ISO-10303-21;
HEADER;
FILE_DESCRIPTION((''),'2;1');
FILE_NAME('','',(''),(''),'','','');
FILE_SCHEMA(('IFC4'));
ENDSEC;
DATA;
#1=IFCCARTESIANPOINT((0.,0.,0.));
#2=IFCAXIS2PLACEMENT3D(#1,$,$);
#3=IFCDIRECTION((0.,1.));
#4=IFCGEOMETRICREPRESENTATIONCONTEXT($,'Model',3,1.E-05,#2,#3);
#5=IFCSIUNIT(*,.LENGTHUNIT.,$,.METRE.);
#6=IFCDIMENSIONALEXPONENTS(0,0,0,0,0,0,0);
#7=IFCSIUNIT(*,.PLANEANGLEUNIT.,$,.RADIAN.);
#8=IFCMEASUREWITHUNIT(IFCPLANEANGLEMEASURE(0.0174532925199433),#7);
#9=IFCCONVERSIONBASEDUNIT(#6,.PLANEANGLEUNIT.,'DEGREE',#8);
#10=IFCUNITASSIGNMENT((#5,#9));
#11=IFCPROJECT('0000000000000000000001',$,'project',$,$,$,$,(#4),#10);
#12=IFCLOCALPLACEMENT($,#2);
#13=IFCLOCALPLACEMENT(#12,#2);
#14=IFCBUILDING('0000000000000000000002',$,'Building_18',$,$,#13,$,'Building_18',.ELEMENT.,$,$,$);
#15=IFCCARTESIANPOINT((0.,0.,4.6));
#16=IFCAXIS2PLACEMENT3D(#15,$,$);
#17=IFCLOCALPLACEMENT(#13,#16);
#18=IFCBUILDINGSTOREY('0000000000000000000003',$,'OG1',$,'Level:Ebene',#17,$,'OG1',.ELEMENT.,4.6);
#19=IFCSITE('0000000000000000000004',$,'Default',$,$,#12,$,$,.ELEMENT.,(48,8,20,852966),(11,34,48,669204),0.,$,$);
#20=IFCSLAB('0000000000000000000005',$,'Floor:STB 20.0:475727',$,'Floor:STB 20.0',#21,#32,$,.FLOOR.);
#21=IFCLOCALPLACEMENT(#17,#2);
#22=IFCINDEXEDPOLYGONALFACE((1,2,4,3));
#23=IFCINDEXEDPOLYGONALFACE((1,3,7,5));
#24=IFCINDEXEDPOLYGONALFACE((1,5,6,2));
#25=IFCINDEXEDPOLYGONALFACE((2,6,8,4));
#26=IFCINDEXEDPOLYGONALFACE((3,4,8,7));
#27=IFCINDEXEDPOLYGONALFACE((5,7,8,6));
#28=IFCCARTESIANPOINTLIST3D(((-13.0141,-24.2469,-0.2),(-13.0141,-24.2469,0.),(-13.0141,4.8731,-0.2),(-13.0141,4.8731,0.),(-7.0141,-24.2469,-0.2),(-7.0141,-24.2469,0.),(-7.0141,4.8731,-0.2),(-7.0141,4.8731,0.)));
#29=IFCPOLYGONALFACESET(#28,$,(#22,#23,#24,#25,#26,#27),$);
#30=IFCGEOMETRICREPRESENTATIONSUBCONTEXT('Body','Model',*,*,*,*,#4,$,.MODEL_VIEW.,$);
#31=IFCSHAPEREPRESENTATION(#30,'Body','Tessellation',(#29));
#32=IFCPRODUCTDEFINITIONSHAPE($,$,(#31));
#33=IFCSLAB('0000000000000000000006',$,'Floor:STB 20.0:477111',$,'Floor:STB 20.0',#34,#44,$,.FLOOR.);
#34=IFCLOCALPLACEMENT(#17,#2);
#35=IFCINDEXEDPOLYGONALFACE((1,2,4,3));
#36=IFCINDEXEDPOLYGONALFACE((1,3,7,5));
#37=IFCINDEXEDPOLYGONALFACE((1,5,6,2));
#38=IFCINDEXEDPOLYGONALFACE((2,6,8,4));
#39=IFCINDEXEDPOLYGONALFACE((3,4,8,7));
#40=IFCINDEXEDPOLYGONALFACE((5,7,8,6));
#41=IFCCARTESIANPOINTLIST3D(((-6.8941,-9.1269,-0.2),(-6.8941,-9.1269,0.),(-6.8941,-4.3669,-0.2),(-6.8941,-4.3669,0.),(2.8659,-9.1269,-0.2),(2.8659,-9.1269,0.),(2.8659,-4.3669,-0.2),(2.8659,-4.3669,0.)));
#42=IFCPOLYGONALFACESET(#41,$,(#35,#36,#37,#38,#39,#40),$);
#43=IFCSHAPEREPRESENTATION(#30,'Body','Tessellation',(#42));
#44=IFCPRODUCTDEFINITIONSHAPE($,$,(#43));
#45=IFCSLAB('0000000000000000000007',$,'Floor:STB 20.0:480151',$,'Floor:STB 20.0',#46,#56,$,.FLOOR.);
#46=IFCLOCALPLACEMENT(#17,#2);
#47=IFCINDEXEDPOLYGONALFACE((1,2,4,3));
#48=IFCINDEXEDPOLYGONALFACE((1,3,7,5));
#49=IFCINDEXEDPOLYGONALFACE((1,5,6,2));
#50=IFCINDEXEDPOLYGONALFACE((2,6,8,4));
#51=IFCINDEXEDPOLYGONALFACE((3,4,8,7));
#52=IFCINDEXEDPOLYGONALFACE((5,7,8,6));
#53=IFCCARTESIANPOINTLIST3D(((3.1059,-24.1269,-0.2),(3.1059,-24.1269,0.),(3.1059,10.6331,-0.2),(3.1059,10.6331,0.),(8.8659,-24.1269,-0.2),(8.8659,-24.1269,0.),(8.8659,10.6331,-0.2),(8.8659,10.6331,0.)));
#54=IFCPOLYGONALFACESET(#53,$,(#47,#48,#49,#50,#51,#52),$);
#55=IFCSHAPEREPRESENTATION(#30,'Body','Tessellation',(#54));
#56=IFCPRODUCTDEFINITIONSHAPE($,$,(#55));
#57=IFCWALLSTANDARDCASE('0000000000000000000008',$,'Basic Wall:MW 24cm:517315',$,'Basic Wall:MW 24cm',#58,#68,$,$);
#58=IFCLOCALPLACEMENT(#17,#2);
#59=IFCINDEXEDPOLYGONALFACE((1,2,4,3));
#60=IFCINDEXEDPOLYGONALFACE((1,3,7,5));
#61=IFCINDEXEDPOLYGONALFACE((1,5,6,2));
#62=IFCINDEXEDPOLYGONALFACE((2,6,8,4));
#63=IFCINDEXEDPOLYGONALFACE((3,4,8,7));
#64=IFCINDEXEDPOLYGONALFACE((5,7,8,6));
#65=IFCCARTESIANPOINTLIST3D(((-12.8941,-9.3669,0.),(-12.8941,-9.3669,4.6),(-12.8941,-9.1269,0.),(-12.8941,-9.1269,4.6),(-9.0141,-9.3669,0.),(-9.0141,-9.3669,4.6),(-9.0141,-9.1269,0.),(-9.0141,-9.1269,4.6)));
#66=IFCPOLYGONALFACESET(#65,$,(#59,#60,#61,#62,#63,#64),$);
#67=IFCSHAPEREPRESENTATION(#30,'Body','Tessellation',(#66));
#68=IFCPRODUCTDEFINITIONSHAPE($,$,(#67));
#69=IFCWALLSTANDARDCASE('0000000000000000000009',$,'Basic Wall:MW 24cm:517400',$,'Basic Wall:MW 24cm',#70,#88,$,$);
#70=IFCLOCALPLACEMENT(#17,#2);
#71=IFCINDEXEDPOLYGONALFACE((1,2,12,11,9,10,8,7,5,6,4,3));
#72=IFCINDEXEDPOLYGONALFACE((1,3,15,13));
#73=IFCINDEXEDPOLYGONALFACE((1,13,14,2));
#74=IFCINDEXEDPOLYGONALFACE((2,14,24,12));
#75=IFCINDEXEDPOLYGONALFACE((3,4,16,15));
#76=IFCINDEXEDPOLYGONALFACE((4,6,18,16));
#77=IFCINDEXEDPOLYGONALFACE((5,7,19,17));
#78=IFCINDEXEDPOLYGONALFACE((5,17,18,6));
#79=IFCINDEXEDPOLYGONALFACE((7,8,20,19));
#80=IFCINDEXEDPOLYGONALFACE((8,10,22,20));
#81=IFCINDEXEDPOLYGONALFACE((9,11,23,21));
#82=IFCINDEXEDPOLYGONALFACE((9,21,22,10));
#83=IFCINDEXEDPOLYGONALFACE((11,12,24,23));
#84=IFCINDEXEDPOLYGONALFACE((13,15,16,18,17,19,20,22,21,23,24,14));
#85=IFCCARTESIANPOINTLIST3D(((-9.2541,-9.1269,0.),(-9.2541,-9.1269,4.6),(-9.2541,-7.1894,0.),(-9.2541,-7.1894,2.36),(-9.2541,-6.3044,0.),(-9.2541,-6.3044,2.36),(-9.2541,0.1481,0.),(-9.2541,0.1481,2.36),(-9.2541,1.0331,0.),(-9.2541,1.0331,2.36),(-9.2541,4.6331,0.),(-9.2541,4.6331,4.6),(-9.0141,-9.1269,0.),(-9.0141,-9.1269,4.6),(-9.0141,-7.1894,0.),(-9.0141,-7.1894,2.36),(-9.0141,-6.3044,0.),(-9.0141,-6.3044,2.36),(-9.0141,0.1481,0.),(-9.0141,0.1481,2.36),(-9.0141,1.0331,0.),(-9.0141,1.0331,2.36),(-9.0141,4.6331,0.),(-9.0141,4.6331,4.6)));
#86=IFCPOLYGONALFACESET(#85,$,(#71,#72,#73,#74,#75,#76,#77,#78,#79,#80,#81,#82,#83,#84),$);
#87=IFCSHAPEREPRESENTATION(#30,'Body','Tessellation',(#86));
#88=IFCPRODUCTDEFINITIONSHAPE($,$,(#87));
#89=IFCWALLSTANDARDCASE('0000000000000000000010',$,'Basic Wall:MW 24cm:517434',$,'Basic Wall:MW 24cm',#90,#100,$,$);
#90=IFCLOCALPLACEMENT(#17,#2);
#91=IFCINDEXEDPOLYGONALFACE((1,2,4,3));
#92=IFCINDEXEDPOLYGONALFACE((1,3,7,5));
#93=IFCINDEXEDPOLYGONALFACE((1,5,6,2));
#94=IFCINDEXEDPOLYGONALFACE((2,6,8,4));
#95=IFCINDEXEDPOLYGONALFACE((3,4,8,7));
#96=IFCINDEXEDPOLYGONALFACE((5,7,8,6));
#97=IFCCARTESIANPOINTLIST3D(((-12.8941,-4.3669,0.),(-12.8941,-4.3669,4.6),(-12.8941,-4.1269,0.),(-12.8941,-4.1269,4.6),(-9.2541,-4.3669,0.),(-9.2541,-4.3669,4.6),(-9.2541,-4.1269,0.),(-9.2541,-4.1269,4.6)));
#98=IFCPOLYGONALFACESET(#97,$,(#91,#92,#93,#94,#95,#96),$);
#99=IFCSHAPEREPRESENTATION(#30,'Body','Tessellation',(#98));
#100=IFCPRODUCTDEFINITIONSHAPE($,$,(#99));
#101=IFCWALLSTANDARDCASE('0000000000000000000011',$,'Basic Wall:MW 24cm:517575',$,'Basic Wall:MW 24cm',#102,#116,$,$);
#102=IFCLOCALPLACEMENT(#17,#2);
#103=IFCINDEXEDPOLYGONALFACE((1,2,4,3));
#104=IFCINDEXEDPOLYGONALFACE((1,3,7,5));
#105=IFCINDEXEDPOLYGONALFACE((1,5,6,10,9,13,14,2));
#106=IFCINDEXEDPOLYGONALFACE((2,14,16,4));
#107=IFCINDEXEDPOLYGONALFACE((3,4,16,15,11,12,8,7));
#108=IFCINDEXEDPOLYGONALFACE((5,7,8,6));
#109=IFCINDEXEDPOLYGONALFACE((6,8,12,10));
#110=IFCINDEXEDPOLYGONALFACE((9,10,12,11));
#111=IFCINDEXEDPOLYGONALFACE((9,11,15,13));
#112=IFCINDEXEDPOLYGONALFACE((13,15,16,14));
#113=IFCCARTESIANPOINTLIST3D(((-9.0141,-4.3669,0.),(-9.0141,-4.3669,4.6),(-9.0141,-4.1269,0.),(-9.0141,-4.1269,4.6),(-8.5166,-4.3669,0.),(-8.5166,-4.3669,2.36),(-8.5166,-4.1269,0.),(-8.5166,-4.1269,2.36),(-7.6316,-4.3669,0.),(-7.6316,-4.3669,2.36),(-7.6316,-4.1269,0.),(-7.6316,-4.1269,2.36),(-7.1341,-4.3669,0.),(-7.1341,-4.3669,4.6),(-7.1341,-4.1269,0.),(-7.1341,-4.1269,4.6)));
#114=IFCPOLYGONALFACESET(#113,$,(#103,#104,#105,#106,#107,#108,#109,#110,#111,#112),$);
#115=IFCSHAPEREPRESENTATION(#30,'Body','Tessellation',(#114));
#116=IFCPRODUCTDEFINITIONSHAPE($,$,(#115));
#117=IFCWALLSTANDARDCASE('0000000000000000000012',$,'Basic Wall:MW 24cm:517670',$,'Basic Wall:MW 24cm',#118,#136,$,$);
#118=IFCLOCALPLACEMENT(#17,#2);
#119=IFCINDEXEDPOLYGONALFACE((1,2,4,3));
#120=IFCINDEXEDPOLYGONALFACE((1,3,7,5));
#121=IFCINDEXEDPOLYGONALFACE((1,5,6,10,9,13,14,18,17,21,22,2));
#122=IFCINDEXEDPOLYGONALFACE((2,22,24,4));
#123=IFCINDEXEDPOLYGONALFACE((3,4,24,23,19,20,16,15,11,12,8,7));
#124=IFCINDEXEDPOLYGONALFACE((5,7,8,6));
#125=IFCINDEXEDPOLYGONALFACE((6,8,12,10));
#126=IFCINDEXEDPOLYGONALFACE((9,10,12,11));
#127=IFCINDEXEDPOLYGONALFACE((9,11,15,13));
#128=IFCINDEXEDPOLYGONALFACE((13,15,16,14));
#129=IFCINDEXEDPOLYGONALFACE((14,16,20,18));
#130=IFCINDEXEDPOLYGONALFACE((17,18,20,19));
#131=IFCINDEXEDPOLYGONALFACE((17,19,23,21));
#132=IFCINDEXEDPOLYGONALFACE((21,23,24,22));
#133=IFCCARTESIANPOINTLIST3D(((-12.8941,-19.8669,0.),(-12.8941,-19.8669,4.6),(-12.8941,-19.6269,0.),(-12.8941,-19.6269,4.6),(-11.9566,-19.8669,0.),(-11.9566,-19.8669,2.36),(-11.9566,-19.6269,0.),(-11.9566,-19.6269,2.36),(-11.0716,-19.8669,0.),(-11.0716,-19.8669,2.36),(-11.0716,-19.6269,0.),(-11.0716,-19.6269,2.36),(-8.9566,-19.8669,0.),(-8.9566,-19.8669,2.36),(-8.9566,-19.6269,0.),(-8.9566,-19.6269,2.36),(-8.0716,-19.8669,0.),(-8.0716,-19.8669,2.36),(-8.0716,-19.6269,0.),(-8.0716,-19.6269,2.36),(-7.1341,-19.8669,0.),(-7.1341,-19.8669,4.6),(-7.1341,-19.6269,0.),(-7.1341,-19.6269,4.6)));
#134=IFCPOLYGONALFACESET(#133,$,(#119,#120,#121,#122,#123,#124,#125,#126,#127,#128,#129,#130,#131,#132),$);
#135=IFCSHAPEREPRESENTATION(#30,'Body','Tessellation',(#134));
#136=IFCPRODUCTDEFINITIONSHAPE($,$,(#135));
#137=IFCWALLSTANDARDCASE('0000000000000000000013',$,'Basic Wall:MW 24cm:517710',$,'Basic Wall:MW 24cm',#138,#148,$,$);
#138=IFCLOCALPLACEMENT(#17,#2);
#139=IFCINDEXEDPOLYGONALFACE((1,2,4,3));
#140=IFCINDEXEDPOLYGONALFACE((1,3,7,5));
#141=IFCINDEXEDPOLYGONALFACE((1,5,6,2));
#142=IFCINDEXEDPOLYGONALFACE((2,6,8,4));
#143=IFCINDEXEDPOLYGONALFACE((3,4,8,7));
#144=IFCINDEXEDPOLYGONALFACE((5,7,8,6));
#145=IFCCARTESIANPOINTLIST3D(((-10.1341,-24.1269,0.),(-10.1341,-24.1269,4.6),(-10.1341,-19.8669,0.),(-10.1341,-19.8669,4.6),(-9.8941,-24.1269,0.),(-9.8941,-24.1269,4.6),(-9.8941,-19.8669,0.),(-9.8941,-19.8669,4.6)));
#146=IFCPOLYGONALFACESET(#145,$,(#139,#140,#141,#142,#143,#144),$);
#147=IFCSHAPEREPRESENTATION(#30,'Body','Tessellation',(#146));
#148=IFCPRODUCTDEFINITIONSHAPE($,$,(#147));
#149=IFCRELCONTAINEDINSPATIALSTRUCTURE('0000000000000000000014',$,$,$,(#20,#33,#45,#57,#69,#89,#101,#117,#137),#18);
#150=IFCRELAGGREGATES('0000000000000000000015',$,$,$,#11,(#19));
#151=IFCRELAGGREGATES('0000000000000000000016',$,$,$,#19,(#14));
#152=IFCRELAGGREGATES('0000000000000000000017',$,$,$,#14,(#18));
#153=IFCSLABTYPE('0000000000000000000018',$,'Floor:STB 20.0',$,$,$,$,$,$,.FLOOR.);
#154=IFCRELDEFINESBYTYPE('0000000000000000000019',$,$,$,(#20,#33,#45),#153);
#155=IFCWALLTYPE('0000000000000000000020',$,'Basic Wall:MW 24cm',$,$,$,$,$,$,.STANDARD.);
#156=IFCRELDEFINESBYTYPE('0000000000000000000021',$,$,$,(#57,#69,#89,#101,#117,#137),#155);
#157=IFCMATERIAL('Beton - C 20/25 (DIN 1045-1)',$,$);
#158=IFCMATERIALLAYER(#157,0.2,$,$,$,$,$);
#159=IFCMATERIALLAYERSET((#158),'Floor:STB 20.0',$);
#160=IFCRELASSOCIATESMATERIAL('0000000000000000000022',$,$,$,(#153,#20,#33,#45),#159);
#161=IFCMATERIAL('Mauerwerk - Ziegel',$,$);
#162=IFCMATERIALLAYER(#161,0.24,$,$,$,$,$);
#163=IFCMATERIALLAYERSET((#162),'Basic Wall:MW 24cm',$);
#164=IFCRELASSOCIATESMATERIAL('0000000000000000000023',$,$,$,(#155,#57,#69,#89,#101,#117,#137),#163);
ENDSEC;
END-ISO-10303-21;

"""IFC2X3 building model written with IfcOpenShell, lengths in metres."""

from ifc_helpers import new_model, entity, si_unit, converted_unit, direction, frame, frame_2d, origin, origin_2d_with_axis, place, context, subcontext, project, spatial, rectangle, extrude, material, layer, layer_set, layer_usage, type_object, element, save


model = new_model("IFC2X3")

# Units and contexts
model_context = context("Model", 3, precision=1e-05, world=origin(), true_north=direction((0.0, 1.0)))
body_context = subcontext(model_context, "Body", "Model", "MODEL_VIEW")
ifc_project = project(units=[si_unit("LENGTHUNIT", "METRE"), converted_unit("PLANEANGLEUNIT", "DEGREE", entity("IfcPlaneAngleMeasure", 0.0174532925199433), si_unit("PLANEANGLEUNIT", "RADIAN"), dimensions=[0, 0, 0, 0, 0, 0, 0])], contexts=[model_context])

# Site, building, storey
site_placement = place(None, origin())
site = spatial("IfcSite", under=ifc_project, at=site_placement, Name="Default", CompositionType="ELEMENT", RefLatitude=(48, 8, 20, 852966), RefLongitude=(11, 34, 48, 669204), RefElevation=0.0)
building_placement = place(site_placement, origin())
building = spatial("IfcBuilding", under=site, at=building_placement, Name="Building_18", LongName="Building_18", CompositionType="ELEMENT")
storey_placement = place(building_placement, frame((0.0, 0.0, 4.6)))
storey = spatial("IfcBuildingStorey", under=building, at=storey_placement, Name="OG1", ObjectType="Level:Ebene", LongName="OG1", CompositionType="ELEMENT", Elevation=4.6)

# Slabs
ifc_material_1 = material(Name="Beton - C 20/25 (DIN 1045-1)")
ifc_layer_1 = layer(ifc_material_1, 0.2)
ifc_layer_set_1 = layer_set([ifc_layer_1], Name="Floor:STB 20.0")
ifc_layer_usage_1 = layer_usage(ifc_layer_set_1, "AXIS3", "POSITIVE", 0.0)
slab_type = type_object("IfcSlabType", Name="Floor:STB 20.0", PredefinedType="FLOOR", material=ifc_layer_set_1)
slab_1_placement = place(storey_placement, origin())
element("IfcSlab", 1, at=slab_1_placement, inside=storey, type_object=slab_type, material=ifc_layer_usage_1, Name="Floor:STB 20.0:475727", ObjectType="Floor:STB 20.0", PredefinedType="FLOOR", context=body_context, shape_type="SweptSolid", body=[
    extrude(rectangle(XDim=29.12, YDim=6.0, at=frame_2d((0.0, 0.0), x_axis=(1.0, 0.0))), frame((-10.0141, -9.6869, 0.0), z_axis=(0.0, 0.0, -1.0), x_axis=(0.0, 1.0, 0.0)), (0.0, 0.0, 1.0), 0.2),
])
ifc_layer_usage_2 = layer_usage(ifc_layer_set_1, "AXIS3", "POSITIVE", 0.0)
slab_2_placement = place(storey_placement, origin())
element("IfcSlab", 2, at=slab_2_placement, inside=storey, type_object=slab_type, material=ifc_layer_usage_2, Name="Floor:STB 20.0:477111", ObjectType="Floor:STB 20.0", PredefinedType="FLOOR", context=body_context, shape_type="SweptSolid", body=[
    extrude(rectangle(XDim=4.76, YDim=9.76, at=frame_2d((0.0, 0.0), x_axis=(1.0, 0.0))), frame((-2.0141, -6.7469, 0.0), z_axis=(0.0, 0.0, -1.0), x_axis=(0.0, 1.0, 0.0)), (0.0, 0.0, 1.0), 0.2),
])
ifc_layer_usage_3 = layer_usage(ifc_layer_set_1, "AXIS3", "POSITIVE", 0.0)
slab_3_placement = place(storey_placement, origin())
element("IfcSlab", 3, at=slab_3_placement, inside=storey, type_object=slab_type, material=ifc_layer_usage_3, Name="Floor:STB 20.0:480151", ObjectType="Floor:STB 20.0", PredefinedType="FLOOR", context=body_context, shape_type="SweptSolid", body=[
    extrude(rectangle(XDim=34.76, YDim=5.76, at=origin_2d_with_axis()), frame((5.9859, -6.7469, 0.0), z_axis=(0.0, 0.0, -1.0), x_axis=(0.0, 1.0, 0.0)), (0.0, 0.0, 1.0), 0.2),
])

# Wall
ifc_material_2 = material(Name="Mauerwerk - Ziegel")
ifc_layer_2 = layer(ifc_material_2, 0.24)
ifc_layer_set_2 = layer_set([ifc_layer_2], Name="Basic Wall:MW 24cm")
ifc_layer_usage_4 = layer_usage(ifc_layer_set_2, "AXIS2", "NEGATIVE", 0.12)
wall_type = type_object("IfcWallType", Name="Basic Wall:MW 24cm", PredefinedType="STANDARD", material=ifc_layer_set_2)
wall_1_placement = place(storey_placement, frame((-12.8941, -9.2469, 0.0)))
element("IfcWallStandardCase", 4, at=wall_1_placement, inside=storey, type_object=wall_type, material=ifc_layer_usage_4, Name="Basic Wall:MW 24cm:517315", ObjectType="Basic Wall:MW 24cm", context=body_context, shape_type="SweptSolid", body=[
    extrude(rectangle(XDim=3.88, YDim=0.24, at=frame_2d((1.94, 0.0), x_axis=(-1.0, 0.0))), origin(), (0.0, 0.0, 1.0), 4.6),
])

# Wall, openings
ifc_layer_usage_5 = layer_usage(ifc_layer_set_2, "AXIS2", "NEGATIVE", 0.12)
wall_2_placement = place(storey_placement, frame((-9.1341, -9.1269, 0.0), z_axis=(0.0, 0.0, 1.0), x_axis=(0.0, 1.0, 0.0)))
wall_2 = element("IfcWallStandardCase", 5, at=wall_2_placement, inside=storey, type_object=wall_type, material=ifc_layer_usage_5, Name="Basic Wall:MW 24cm:517400", ObjectType="Basic Wall:MW 24cm", context=body_context, shape_type="SweptSolid", body=[
    extrude(rectangle(XDim=13.76, YDim=0.24, at=frame_2d((6.88, 0.0), x_axis=(-1.0, 0.0))), origin(), (0.0, 0.0, 1.0), 4.6),
])
opening_1_placement = place(wall_2_placement, frame((1.9375, -0.12, 0.0)))
element("IfcOpeningElement", 6, at=opening_1_placement, cuts=wall_2, ObjectType="Opening", context=body_context, shape_type="SweptSolid", body=[
    extrude(rectangle(XDim=2.36, YDim=0.885, at=frame_2d((1.18, 0.4425), x_axis=(1.0, 0.0))), frame((0.0, 0.0, 0.0), z_axis=(0.0, 1.0, 0.0), x_axis=(0.0, 0.0, 1.0)), (0.0, 0.0, 1.0), 0.24),
])
opening_2_placement = place(wall_2_placement, frame((9.275, -0.12, 0.0)))
element("IfcOpeningElement", 7, at=opening_2_placement, cuts=wall_2, ObjectType="Opening", context=body_context, shape_type="SweptSolid", body=[
    extrude(rectangle(XDim=2.36, YDim=0.885, at=frame_2d((1.18, 0.4425), x_axis=(1.0, 0.0))), frame((0.0, 0.0, 0.0), z_axis=(0.0, 1.0, 0.0), x_axis=(0.0, 0.0, 1.0)), (0.0, 0.0, 1.0), 0.24),
])

# Wall
ifc_layer_usage_6 = layer_usage(ifc_layer_set_2, "AXIS2", "NEGATIVE", 0.12)
wall_3_placement = place(storey_placement, frame((-12.8941, -4.2469, 0.0)))
element("IfcWallStandardCase", 8, at=wall_3_placement, inside=storey, type_object=wall_type, material=ifc_layer_usage_6, Name="Basic Wall:MW 24cm:517434", ObjectType="Basic Wall:MW 24cm", context=body_context, shape_type="SweptSolid", body=[
    extrude(rectangle(XDim=3.64, YDim=0.24, at=frame_2d((1.82, 0.0), x_axis=(-1.0, 0.0))), origin(), (0.0, 0.0, 1.0), 4.6),
])

# Wall, opening
ifc_layer_usage_7 = layer_usage(ifc_layer_set_2, "AXIS2", "NEGATIVE", 0.12)
wall_4_placement = place(storey_placement, frame((-9.0141, -4.2469, 0.0)))
wall_4 = element("IfcWallStandardCase", 9, at=wall_4_placement, inside=storey, type_object=wall_type, material=ifc_layer_usage_7, Name="Basic Wall:MW 24cm:517575", ObjectType="Basic Wall:MW 24cm", context=body_context, shape_type="SweptSolid", body=[
    extrude(rectangle(XDim=1.88, YDim=0.24, at=frame_2d((0.94, 0.0), x_axis=(1.0, 0.0))), origin(), (0.0, 0.0, 1.0), 4.6),
])
opening_3_placement = place(wall_4_placement, frame((1.3825, 0.12, 0.0)))
element("IfcOpeningElement", 10, at=opening_3_placement, cuts=wall_4, ObjectType="Opening", context=body_context, shape_type="SweptSolid", body=[
    extrude(rectangle(XDim=2.36, YDim=0.885, at=frame_2d((1.18, 0.4425), x_axis=(1.0, 0.0))), frame((0.0, 0.0, 0.0), z_axis=(0.0, -1.0, 0.0), x_axis=(0.0, 0.0, 1.0)), (0.0, 0.0, 1.0), 0.24),
])

# Wall, openings
ifc_layer_usage_8 = layer_usage(ifc_layer_set_2, "AXIS2", "POSITIVE", -0.12)
wall_5_placement = place(storey_placement, frame((-12.8941, -19.7469, 0.0)))
wall_5 = element("IfcWallStandardCase", 11, at=wall_5_placement, inside=storey, type_object=wall_type, material=ifc_layer_usage_8, Name="Basic Wall:MW 24cm:517670", ObjectType="Basic Wall:MW 24cm", context=body_context, shape_type="SweptSolid", body=[
    extrude(rectangle(XDim=5.76, YDim=0.24, at=frame_2d((2.88, 0.0), x_axis=(1.0, 0.0))), origin(), (0.0, 0.0, 1.0), 4.6),
])
opening_4_placement = place(wall_5_placement, frame((1.8225, 0.12, 0.0)))
element("IfcOpeningElement", 12, at=opening_4_placement, cuts=wall_5, ObjectType="Opening", context=body_context, shape_type="SweptSolid", body=[
    extrude(rectangle(XDim=2.36, YDim=0.885, at=frame_2d((1.18, 0.4425), x_axis=(1.0, 0.0))), frame((0.0, 0.0, 0.0), z_axis=(0.0, -1.0, 0.0), x_axis=(0.0, 0.0, 1.0)), (0.0, 0.0, 1.0), 0.24),
])
opening_5_placement = place(wall_5_placement, frame((4.8225, 0.12, 0.0)))
element("IfcOpeningElement", 13, at=opening_5_placement, cuts=wall_5, ObjectType="Opening", context=body_context, shape_type="SweptSolid", body=[
    extrude(rectangle(XDim=2.36, YDim=0.885, at=frame_2d((1.18, 0.4425), x_axis=(1.0, 0.0))), frame((0.0, 0.0, 0.0), z_axis=(0.0, -1.0, 0.0), x_axis=(0.0, 0.0, 1.0)), (0.0, 0.0, 1.0), 0.24),
])

# Wall
ifc_layer_usage_9 = layer_usage(ifc_layer_set_2, "AXIS2", "NEGATIVE", 0.12)
wall_6_placement = place(storey_placement, frame((-10.0141, -19.8669, 0.0), z_axis=(0.0, 0.0, 1.0), x_axis=(0.0, -1.0, 0.0)))
element("IfcWallStandardCase", 14, at=wall_6_placement, inside=storey, type_object=wall_type, material=ifc_layer_usage_9, Name="Basic Wall:MW 24cm:517710", ObjectType="Basic Wall:MW 24cm", context=body_context, shape_type="SweptSolid", body=[
    extrude(rectangle(XDim=4.26, YDim=0.24, at=frame_2d((2.13, 0.0), x_axis=(-1.0, 0.0))), origin(), (0.0, 0.0, 1.0), 4.6),
])

save(model, "model.ifc")
